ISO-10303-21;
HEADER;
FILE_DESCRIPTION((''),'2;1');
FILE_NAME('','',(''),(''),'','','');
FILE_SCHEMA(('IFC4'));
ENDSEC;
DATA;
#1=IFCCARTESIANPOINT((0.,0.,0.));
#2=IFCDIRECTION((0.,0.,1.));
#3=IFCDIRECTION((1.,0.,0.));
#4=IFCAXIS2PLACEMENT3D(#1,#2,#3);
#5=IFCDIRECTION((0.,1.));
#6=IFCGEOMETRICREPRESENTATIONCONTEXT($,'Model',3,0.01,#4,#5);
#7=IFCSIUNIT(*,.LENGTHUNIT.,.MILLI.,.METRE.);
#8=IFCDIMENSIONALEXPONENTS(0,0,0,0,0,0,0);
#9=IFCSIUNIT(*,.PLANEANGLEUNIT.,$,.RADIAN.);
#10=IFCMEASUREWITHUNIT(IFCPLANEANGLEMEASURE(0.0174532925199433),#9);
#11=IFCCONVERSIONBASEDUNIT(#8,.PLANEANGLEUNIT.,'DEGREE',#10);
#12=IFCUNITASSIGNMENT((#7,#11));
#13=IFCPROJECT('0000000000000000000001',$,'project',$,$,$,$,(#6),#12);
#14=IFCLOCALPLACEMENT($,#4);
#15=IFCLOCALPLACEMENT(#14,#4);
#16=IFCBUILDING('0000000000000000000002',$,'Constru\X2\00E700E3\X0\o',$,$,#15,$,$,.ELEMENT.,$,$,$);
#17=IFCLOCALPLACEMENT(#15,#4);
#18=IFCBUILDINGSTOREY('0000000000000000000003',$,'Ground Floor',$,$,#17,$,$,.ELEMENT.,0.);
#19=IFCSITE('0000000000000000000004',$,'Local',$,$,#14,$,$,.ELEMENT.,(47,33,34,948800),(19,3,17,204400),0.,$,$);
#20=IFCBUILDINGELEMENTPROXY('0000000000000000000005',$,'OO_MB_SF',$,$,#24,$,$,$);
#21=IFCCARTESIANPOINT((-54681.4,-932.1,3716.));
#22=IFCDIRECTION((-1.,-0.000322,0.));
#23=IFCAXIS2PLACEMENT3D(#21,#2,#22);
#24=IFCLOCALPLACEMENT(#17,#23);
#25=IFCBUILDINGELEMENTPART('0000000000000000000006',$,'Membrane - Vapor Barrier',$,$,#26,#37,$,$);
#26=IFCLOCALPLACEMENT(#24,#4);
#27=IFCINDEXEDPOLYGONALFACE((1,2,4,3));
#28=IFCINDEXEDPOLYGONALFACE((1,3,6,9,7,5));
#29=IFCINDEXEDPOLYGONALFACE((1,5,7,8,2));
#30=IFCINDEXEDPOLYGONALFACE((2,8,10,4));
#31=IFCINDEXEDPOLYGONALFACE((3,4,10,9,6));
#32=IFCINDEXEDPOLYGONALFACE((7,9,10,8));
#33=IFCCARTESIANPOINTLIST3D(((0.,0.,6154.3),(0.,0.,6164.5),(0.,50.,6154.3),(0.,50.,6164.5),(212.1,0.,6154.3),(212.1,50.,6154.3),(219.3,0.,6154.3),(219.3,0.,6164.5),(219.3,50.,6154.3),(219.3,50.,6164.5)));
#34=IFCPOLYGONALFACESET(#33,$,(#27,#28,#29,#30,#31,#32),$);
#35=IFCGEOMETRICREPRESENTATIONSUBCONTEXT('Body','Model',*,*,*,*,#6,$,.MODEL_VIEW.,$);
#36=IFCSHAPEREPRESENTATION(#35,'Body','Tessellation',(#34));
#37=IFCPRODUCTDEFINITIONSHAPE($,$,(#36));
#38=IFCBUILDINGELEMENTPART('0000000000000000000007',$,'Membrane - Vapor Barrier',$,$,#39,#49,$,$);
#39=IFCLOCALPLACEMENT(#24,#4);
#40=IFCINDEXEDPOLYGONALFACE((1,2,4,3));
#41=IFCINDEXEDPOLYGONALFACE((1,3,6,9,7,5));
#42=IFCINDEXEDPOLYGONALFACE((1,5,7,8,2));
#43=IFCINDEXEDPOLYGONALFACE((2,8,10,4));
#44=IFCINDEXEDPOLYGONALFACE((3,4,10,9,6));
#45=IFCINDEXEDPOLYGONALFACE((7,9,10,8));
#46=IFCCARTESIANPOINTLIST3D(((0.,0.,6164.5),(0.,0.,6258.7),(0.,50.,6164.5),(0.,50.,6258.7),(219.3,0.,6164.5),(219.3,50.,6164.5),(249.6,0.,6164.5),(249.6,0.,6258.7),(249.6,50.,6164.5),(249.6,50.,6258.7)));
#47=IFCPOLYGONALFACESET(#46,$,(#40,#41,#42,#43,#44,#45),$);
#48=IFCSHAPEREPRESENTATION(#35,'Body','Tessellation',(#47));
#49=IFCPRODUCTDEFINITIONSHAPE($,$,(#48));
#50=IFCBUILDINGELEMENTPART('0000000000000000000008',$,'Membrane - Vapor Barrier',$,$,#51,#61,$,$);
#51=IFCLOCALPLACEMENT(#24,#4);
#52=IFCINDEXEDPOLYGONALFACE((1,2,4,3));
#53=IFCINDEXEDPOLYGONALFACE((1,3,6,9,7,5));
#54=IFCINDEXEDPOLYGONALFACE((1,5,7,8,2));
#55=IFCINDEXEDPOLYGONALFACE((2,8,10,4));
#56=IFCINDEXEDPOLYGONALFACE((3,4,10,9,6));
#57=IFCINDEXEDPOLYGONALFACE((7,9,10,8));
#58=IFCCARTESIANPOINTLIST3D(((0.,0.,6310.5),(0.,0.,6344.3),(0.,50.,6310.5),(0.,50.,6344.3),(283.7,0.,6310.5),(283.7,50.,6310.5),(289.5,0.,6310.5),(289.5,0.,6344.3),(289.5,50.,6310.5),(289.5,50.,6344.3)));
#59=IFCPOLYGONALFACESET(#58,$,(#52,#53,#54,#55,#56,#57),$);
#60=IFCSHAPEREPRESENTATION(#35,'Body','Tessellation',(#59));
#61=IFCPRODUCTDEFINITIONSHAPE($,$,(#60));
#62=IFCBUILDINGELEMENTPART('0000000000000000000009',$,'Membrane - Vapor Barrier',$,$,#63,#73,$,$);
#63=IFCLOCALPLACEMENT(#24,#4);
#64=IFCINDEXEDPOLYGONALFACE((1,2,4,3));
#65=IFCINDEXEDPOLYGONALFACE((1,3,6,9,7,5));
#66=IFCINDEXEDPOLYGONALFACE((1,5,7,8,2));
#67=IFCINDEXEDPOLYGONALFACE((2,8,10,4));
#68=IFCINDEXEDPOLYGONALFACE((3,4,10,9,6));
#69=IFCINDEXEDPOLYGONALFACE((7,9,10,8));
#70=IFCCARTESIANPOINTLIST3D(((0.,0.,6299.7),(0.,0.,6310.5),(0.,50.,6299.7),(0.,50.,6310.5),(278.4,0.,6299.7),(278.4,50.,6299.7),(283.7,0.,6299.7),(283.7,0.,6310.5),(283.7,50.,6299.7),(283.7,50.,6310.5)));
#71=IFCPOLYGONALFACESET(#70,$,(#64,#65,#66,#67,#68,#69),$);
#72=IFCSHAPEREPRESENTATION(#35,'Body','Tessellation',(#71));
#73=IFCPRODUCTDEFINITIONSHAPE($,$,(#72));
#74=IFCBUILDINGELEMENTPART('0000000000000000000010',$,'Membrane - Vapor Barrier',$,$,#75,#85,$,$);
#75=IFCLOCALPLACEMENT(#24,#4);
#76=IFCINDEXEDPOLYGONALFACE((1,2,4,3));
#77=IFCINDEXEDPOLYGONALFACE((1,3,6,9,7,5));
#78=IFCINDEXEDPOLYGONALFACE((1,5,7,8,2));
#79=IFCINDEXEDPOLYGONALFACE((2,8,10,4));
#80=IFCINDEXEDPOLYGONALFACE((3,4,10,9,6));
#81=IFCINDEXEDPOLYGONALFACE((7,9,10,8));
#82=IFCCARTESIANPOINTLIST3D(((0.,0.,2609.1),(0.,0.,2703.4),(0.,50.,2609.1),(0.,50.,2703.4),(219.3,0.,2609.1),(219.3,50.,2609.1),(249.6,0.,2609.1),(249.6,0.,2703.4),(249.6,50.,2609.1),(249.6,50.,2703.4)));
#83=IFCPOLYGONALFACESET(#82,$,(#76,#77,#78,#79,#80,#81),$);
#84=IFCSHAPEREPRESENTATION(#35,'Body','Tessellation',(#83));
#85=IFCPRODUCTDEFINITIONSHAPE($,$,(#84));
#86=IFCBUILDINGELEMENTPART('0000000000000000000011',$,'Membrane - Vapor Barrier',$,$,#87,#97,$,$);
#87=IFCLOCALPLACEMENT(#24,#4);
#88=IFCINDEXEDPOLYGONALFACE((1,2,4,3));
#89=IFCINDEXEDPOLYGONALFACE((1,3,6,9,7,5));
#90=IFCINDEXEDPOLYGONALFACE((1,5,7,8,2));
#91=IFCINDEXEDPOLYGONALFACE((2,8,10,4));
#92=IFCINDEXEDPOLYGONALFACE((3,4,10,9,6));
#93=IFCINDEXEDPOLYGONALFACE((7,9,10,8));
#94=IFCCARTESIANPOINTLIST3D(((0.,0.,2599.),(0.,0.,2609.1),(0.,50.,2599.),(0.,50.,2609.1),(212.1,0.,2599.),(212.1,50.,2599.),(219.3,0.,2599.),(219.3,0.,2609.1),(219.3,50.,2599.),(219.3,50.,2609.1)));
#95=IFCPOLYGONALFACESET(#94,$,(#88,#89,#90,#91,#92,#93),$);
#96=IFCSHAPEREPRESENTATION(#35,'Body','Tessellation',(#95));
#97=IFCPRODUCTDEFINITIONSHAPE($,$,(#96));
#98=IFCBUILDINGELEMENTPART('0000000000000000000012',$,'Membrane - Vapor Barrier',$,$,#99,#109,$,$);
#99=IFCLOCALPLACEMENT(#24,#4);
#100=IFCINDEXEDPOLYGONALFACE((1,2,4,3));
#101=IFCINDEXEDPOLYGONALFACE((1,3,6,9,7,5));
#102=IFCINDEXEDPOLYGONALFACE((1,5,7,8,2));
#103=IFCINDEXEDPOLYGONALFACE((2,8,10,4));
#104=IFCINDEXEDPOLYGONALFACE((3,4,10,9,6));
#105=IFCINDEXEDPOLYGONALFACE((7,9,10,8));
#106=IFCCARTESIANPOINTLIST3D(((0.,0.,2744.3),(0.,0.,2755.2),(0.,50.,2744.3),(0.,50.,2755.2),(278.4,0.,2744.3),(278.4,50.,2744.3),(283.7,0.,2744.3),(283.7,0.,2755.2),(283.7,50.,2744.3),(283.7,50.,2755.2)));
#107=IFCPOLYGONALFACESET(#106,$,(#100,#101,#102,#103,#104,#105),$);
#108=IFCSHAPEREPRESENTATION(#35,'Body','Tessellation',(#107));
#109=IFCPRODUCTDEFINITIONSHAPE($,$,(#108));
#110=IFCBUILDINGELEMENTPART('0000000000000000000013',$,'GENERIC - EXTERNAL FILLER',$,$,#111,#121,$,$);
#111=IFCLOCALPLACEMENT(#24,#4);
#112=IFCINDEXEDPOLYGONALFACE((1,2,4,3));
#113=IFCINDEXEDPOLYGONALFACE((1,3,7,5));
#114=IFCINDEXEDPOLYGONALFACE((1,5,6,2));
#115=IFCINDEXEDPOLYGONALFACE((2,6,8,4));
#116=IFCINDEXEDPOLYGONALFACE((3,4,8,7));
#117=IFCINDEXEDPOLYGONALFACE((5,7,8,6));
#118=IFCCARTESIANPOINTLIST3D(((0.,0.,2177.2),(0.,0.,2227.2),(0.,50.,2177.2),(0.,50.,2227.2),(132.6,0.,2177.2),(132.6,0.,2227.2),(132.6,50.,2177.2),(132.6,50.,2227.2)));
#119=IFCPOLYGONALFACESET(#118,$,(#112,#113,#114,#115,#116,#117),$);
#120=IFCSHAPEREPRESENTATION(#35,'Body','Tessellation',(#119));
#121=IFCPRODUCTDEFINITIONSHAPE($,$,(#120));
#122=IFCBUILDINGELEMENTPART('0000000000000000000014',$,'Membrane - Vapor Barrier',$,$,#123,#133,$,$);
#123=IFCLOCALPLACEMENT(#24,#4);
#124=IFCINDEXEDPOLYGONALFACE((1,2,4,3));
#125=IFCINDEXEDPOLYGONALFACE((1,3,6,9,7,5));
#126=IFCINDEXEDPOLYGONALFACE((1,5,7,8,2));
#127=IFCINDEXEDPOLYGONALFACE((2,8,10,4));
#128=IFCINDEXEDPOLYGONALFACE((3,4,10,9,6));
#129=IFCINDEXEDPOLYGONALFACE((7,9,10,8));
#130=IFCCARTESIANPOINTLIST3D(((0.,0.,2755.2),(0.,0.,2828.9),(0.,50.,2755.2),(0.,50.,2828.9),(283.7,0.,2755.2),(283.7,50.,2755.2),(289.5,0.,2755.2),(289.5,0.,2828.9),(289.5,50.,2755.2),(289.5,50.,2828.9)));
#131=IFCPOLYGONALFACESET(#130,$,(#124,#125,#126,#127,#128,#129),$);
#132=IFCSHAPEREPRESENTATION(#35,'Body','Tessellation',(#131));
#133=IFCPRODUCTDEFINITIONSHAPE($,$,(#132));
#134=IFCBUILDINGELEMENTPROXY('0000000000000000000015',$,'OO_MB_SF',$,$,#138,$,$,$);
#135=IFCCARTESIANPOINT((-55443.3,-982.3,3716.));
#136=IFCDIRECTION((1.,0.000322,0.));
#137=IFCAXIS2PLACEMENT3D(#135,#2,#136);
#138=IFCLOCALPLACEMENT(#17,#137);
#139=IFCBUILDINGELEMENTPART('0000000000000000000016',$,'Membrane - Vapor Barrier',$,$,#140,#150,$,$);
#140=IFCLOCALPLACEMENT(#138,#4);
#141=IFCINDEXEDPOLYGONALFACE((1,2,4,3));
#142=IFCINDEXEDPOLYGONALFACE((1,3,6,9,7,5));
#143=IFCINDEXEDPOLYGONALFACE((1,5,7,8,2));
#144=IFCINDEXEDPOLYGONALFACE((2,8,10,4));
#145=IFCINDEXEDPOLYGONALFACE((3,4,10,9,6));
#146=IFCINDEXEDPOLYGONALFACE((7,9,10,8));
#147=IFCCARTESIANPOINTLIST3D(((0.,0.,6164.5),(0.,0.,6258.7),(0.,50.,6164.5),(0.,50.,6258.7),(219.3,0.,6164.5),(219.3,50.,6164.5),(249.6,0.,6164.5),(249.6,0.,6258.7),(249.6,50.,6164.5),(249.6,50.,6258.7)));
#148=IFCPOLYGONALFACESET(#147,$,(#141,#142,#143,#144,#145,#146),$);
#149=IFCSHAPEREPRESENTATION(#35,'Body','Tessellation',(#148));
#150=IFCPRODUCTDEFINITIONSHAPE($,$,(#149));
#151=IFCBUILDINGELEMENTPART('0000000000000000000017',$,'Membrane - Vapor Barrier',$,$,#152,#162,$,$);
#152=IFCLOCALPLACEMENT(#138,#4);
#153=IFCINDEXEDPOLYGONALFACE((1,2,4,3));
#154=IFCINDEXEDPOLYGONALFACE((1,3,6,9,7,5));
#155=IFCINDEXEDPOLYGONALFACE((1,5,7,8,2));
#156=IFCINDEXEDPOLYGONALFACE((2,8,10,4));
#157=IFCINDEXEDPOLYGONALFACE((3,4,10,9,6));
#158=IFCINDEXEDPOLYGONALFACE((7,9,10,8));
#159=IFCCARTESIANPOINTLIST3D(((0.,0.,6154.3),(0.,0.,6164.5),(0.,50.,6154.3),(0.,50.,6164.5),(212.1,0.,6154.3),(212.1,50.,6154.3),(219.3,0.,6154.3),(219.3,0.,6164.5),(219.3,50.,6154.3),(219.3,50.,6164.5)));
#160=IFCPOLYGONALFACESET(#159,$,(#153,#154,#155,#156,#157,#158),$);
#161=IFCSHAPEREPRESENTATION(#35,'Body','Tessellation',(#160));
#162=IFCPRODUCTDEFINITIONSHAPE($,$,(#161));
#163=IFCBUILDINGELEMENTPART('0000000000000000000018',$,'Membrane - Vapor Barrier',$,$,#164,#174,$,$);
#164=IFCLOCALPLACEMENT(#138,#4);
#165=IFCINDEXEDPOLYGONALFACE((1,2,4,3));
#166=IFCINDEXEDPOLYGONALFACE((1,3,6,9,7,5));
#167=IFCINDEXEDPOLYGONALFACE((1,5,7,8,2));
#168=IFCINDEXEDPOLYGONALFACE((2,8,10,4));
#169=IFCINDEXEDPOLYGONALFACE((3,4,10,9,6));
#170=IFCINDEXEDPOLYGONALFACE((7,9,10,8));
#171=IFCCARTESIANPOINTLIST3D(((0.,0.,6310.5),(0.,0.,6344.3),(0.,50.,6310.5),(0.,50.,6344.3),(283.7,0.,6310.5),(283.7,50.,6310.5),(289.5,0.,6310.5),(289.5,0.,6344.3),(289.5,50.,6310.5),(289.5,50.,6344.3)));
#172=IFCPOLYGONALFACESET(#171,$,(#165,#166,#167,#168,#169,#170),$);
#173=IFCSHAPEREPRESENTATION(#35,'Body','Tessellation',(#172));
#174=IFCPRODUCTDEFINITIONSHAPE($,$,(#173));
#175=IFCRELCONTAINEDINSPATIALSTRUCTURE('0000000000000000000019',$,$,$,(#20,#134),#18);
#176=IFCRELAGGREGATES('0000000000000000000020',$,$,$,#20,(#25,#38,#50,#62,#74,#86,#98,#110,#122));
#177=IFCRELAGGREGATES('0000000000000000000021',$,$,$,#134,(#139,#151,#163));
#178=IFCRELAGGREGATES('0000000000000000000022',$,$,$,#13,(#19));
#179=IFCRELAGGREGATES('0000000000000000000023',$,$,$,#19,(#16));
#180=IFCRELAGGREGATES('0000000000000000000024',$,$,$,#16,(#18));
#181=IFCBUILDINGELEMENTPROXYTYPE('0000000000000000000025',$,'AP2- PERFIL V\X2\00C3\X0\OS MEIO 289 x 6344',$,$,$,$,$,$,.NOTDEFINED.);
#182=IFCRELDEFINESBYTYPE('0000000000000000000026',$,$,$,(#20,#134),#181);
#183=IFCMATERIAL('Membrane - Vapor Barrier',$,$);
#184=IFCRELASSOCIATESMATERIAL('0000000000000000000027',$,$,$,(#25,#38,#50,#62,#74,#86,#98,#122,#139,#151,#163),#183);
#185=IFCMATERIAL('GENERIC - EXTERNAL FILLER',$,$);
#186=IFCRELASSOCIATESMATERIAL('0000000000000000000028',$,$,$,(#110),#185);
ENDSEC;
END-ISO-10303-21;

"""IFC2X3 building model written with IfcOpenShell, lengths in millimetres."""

from ifc_helpers import new_model, entity, si_unit, converted_unit, direction, frame, origin_with_axes, place, context, subcontext, project, spatial, polyline, outline, extrude, material, type_object, element, aggregate, save


model = new_model("IFC2X3")

# Units and contexts
model_context = context("Model", 3, precision=0.01, world=origin_with_axes(), true_north=direction((0.0, 1.0)))
body_context = subcontext(model_context, "Body", "Model", "MODEL_VIEW")
ifc_project = project(units=[si_unit("LENGTHUNIT", "METRE", prefix="MILLI"), converted_unit("PLANEANGLEUNIT", "DEGREE", entity("IfcPlaneAngleMeasure", 0.0174532925199433), si_unit("PLANEANGLEUNIT", "RADIAN"), dimensions=[0, 0, 0, 0, 0, 0, 0])], contexts=[model_context])

# Site, building, storey
site_placement = place(None, origin_with_axes())
site = spatial("IfcSite", under=ifc_project, at=site_placement, Name="Local", CompositionType="ELEMENT", RefLatitude=(47, 33, 34, 948800), RefLongitude=(19, 3, 17, 204400), RefElevation=0.0)
building_placement = place(site_placement, origin_with_axes())
building = spatial("IfcBuilding", under=site, at=building_placement, Name="Construção", CompositionType="ELEMENT")
storey_placement = place(building_placement, origin_with_axes())
storey = spatial("IfcBuildingStorey", under=building, at=storey_placement, Name="Ground Floor", CompositionType="ELEMENT", Elevation=0.0)

# Building element proxies, building element parts
building_element_proxy_type = type_object("IfcBuildingElementProxyType", Name="AP2- PERFIL VÃOS MEIO 289 x 6344", PredefinedType="NOTDEFINED")
proxy_1_placement = place(storey_placement, frame((-54681.4, -932.1, 3716.0), z_axis=(0.0, 0.0, 1.0), x_axis=(-1.0, -0.000322, 0.0)))
proxy_1 = element("IfcBuildingElementProxy", 1, at=proxy_1_placement, inside=storey, type_object=building_element_proxy_type, Name="OO_MB_SF")
ifc_material_1 = material(Name="Membrane - Vapor Barrier")
building_element_part_1_placement = place(proxy_1_placement, origin_with_axes())
building_element_part_1 = element("IfcBuildingElementPart", 2, at=building_element_part_1_placement, material=ifc_material_1, Name="Membrane - Vapor Barrier", context=body_context, shape_type="SweptSolid", body=[
    extrude(outline(polyline([(0.0, 6154.3), (212.1, 6154.3), (219.3, 6154.3), (219.3, 6164.5), (0.0, 6164.5), (0.0, 6154.3)])), frame((0.0, 50.0, 0.0), z_axis=(0.0, -1.0, 0.0), x_axis=(1.0, 0.0, 0.0)), (0.0, 0.0, 1.0), 50.0),
])
building_element_part_2_placement = place(proxy_1_placement, origin_with_axes())
building_element_part_2 = element("IfcBuildingElementPart", 3, at=building_element_part_2_placement, material=ifc_material_1, Name="Membrane - Vapor Barrier", context=body_context, shape_type="SweptSolid", body=[
    extrude(outline(polyline([(249.6, 6258.7), (0.0, 6258.7), (0.0, 6164.5), (219.3, 6164.5), (249.6, 6164.5), (249.6, 6258.7)])), frame((0.0, 50.0, 0.0), z_axis=(0.0, -1.0, 0.0), x_axis=(1.0, 0.0, 0.0)), (0.0, 0.0, 1.0), 50.0),
])
building_element_part_3_placement = place(proxy_1_placement, origin_with_axes())
building_element_part_3 = element("IfcBuildingElementPart", 4, at=building_element_part_3_placement, material=ifc_material_1, Name="Membrane - Vapor Barrier", context=body_context, shape_type="SweptSolid", body=[
    extrude(outline(polyline([(0.0, 6310.5), (283.7, 6310.5), (289.5, 6310.5), (289.5, 6344.3), (0.0, 6344.3), (0.0, 6310.5)])), frame((0.0, 50.0, 0.0), z_axis=(0.0, -1.0, 0.0), x_axis=(1.0, 0.0, 0.0)), (0.0, 0.0, 1.0), 50.0),
])
building_element_part_4_placement = place(proxy_1_placement, origin_with_axes())
building_element_part_4 = element("IfcBuildingElementPart", 5, at=building_element_part_4_placement, material=ifc_material_1, Name="Membrane - Vapor Barrier", context=body_context, shape_type="SweptSolid", body=[
    extrude(outline(polyline([(0.0, 6299.7), (278.4, 6299.7), (283.7, 6299.7), (283.7, 6310.5), (0.0, 6310.5), (0.0, 6299.7)])), frame((0.0, 50.0, 0.0), z_axis=(0.0, -1.0, 0.0), x_axis=(1.0, 0.0, 0.0)), (0.0, 0.0, 1.0), 50.0),
])
building_element_part_5_placement = place(proxy_1_placement, origin_with_axes())
building_element_part_5 = element("IfcBuildingElementPart", 6, at=building_element_part_5_placement, material=ifc_material_1, Name="Membrane - Vapor Barrier", context=body_context, shape_type="SweptSolid", body=[
    extrude(outline(polyline([(249.6, 2703.4), (0.0, 2703.4), (0.0, 2609.1), (219.3, 2609.1), (249.6, 2609.1), (249.6, 2703.4)])), frame((0.0, 50.0, 0.0), z_axis=(0.0, -1.0, 0.0), x_axis=(1.0, 0.0, 0.0)), (0.0, 0.0, 1.0), 50.0),
])
building_element_part_6_placement = place(proxy_1_placement, origin_with_axes())
building_element_part_6 = element("IfcBuildingElementPart", 7, at=building_element_part_6_placement, material=ifc_material_1, Name="Membrane - Vapor Barrier", context=body_context, shape_type="SweptSolid", body=[
    extrude(outline(polyline([(0.0, 2599.0), (212.1, 2599.0), (219.3, 2599.0), (219.3, 2609.1), (0.0, 2609.1), (0.0, 2599.0)])), frame((0.0, 50.0, 0.0), z_axis=(0.0, -1.0, 0.0), x_axis=(1.0, 0.0, 0.0)), (0.0, 0.0, 1.0), 50.0),
])
building_element_part_7_placement = place(proxy_1_placement, origin_with_axes())
building_element_part_7 = element("IfcBuildingElementPart", 8, at=building_element_part_7_placement, material=ifc_material_1, Name="Membrane - Vapor Barrier", context=body_context, shape_type="SweptSolid", body=[
    extrude(outline(polyline([(0.0, 2744.3), (278.4, 2744.3), (283.7, 2744.3), (283.7, 2755.2), (0.0, 2755.2), (0.0, 2744.3)])), frame((0.0, 50.0, 0.0), z_axis=(0.0, -1.0, 0.0), x_axis=(1.0, 0.0, 0.0)), (0.0, 0.0, 1.0), 50.0),
])
ifc_material_2 = material(Name="GENERIC - EXTERNAL FILLER")
building_element_part_8_placement = place(proxy_1_placement, origin_with_axes())
building_element_part_8 = element("IfcBuildingElementPart", 9, at=building_element_part_8_placement, material=ifc_material_2, Name="GENERIC - EXTERNAL FILLER", context=body_context, shape_type="SweptSolid", body=[
    extrude(outline(polyline([(0.0, 2227.2), (0.0, 2177.2), (132.6, 2177.2), (132.6, 2227.2), (0.0, 2227.2)])), frame((0.0, 50.0, 0.0), z_axis=(0.0, -1.0, 0.0), x_axis=(1.0, 0.0, 0.0)), (0.0, 0.0, 1.0), 50.0),
])
building_element_part_9_placement = place(proxy_1_placement, origin_with_axes())
building_element_part_9 = element("IfcBuildingElementPart", 10, at=building_element_part_9_placement, material=ifc_material_1, Name="Membrane - Vapor Barrier", context=body_context, shape_type="SweptSolid", body=[
    extrude(outline(polyline([(0.0, 2755.2), (283.7, 2755.2), (289.5, 2755.2), (289.5, 2828.9), (0.0, 2828.9), (0.0, 2755.2)])), frame((0.0, 50.0, 0.0), z_axis=(0.0, -1.0, 0.0), x_axis=(1.0, 0.0, 0.0)), (0.0, 0.0, 1.0), 50.0),
])
aggregate(proxy_1, [building_element_part_1, building_element_part_2, building_element_part_3, building_element_part_4, building_element_part_5, building_element_part_6, building_element_part_7, building_element_part_8, building_element_part_9])
proxy_2_placement = place(storey_placement, frame((-55443.3, -982.3, 3716.0), z_axis=(0.0, 0.0, 1.0), x_axis=(1.0, 0.000322, 0.0)))
proxy_2 = element("IfcBuildingElementProxy", 11, at=proxy_2_placement, inside=storey, type_object=building_element_proxy_type, Name="OO_MB_SF")
building_element_part_10_placement = place(proxy_2_placement, origin_with_axes())
building_element_part_10 = element("IfcBuildingElementPart", 12, at=building_element_part_10_placement, material=ifc_material_1, Name="Membrane - Vapor Barrier", context=body_context, shape_type="SweptSolid", body=[
    extrude(outline(polyline([(249.6, 6258.7), (0.0, 6258.7), (0.0, 6164.5), (219.3, 6164.5), (249.6, 6164.5), (249.6, 6258.7)])), frame((0.0, 50.0, 0.0), z_axis=(0.0, -1.0, 0.0), x_axis=(1.0, 0.0, 0.0)), (0.0, 0.0, 1.0), 50.0),
])
building_element_part_11_placement = place(proxy_2_placement, origin_with_axes())
building_element_part_11 = element("IfcBuildingElementPart", 13, at=building_element_part_11_placement, material=ifc_material_1, Name="Membrane - Vapor Barrier", context=body_context, shape_type="SweptSolid", body=[
    extrude(outline(polyline([(0.0, 6154.3), (212.1, 6154.3), (219.3, 6154.3), (219.3, 6164.5), (0.0, 6164.5), (0.0, 6154.3)])), frame((0.0, 50.0, 0.0), z_axis=(0.0, -1.0, 0.0), x_axis=(1.0, 0.0, 0.0)), (0.0, 0.0, 1.0), 50.0),
])
building_element_part_12_placement = place(proxy_2_placement, origin_with_axes())
building_element_part_12 = element("IfcBuildingElementPart", 14, at=building_element_part_12_placement, material=ifc_material_1, Name="Membrane - Vapor Barrier", context=body_context, shape_type="SweptSolid", body=[
    extrude(outline(polyline([(0.0, 6310.5), (283.7, 6310.5), (289.5, 6310.5), (289.5, 6344.3), (0.0, 6344.3), (0.0, 6310.5)])), frame((0.0, 50.0, 0.0), z_axis=(0.0, -1.0, 0.0), x_axis=(1.0, 0.0, 0.0)), (0.0, 0.0, 1.0), 50.0),
])
aggregate(proxy_2, [building_element_part_10, building_element_part_11, building_element_part_12])

save(model, "model.ifc")
